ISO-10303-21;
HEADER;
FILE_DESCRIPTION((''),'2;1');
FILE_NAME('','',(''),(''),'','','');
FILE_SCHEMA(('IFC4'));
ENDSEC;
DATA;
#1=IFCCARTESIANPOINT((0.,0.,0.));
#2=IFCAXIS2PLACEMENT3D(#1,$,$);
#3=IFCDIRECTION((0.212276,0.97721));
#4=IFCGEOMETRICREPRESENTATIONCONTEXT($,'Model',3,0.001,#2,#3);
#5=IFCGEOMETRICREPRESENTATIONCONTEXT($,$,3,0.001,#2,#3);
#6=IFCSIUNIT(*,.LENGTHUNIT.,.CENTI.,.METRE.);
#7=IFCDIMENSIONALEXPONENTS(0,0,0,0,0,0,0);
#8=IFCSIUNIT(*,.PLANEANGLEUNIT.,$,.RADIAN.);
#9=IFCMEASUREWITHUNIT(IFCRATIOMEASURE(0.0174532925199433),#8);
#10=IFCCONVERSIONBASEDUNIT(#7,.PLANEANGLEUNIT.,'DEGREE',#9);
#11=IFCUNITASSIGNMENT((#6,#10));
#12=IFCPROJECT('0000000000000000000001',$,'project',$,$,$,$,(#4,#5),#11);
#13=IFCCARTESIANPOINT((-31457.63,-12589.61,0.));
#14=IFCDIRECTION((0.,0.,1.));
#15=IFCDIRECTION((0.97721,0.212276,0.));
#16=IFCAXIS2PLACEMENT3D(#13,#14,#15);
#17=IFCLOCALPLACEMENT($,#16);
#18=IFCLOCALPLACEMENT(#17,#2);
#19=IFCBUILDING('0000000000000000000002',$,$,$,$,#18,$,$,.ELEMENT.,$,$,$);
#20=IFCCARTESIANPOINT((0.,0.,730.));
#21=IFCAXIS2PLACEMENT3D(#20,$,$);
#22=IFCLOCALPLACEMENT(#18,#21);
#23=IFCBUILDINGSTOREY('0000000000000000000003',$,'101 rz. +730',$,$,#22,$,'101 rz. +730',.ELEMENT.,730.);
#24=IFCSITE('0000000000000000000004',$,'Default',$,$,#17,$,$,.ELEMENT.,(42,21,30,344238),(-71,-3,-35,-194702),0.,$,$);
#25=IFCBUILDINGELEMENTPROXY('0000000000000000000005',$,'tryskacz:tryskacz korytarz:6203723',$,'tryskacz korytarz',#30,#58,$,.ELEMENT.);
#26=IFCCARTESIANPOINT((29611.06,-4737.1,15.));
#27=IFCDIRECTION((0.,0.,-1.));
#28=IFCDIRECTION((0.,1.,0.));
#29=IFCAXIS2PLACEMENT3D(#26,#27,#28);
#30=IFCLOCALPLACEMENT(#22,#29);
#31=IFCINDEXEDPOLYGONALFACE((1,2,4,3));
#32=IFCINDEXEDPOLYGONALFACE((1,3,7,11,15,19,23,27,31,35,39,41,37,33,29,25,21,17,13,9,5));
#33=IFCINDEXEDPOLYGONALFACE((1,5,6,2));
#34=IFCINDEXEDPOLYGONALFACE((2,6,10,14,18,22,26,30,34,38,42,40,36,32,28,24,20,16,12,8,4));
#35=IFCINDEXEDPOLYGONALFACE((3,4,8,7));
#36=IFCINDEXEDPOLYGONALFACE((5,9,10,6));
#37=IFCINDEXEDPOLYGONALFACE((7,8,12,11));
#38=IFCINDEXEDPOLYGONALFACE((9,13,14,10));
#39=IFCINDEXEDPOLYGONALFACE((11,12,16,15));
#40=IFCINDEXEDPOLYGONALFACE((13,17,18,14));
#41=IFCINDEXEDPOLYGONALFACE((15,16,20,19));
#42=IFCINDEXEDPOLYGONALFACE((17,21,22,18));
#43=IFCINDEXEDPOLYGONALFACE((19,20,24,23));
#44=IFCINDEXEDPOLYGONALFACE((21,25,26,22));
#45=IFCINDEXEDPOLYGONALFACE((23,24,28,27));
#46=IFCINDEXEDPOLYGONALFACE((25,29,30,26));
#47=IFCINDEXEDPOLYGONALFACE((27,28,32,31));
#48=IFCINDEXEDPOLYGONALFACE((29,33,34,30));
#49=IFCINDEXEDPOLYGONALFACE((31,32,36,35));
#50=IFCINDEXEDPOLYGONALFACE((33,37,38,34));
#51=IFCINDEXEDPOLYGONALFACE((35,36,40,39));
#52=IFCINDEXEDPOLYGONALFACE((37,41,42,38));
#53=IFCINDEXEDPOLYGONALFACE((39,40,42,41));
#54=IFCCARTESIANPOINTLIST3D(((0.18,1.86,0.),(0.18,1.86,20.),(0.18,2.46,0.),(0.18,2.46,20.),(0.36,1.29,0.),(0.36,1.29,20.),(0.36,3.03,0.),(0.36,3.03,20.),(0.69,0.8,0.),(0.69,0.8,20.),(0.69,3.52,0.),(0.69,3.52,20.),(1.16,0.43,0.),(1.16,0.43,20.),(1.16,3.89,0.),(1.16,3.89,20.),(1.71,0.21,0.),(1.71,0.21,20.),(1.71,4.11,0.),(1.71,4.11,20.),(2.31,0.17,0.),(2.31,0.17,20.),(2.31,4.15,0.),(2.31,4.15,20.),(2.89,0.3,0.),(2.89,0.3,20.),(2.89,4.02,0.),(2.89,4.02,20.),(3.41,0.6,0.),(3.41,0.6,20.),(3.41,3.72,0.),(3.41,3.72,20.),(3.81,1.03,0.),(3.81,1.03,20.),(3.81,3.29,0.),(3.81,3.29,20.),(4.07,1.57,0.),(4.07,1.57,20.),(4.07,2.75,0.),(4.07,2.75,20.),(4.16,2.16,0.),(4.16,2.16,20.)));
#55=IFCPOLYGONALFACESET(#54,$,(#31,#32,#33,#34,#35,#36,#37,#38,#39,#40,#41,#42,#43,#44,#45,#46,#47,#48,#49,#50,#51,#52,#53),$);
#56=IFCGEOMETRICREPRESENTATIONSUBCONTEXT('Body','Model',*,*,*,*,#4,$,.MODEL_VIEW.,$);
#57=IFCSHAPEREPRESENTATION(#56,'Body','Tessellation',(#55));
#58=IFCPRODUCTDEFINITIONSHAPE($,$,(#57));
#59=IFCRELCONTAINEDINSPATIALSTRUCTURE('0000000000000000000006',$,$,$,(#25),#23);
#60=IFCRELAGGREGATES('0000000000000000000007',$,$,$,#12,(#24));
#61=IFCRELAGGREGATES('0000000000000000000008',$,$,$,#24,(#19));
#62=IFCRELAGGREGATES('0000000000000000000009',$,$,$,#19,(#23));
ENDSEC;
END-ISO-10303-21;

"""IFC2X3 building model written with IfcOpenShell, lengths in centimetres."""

from ifc_helpers import new_model, entity, si_unit, converted_unit, direction, frame, frame_2d, origin, place, context, subcontext, project, spatial, circle, extrude, source, transform, mapped, element, save


model = new_model("IFC2X3")

# Units and contexts
model_context = context("Model", 3, precision=0.001, world=origin(), true_north=direction((0.212276, 0.97721)))
context_of_model = context(None, 3, precision=0.001, world=origin(), true_north=direction((0.212276, 0.97721)))
body_context = subcontext(model_context, "Body", "Model", "MODEL_VIEW")
ifc_project = project(units=[si_unit("LENGTHUNIT", "METRE", prefix="CENTI"), converted_unit("PLANEANGLEUNIT", "DEGREE", entity("IfcRatioMeasure", 0.0174532925199433), si_unit("PLANEANGLEUNIT", "RADIAN"), dimensions=[0, 0, 0, 0, 0, 0, 0])], contexts=[model_context, context_of_model])

# Site, building, storey
site_placement = place(None, frame((-31457.63, -12589.61, 0.0), z_axis=(0.0, 0.0, 1.0), x_axis=(0.97721, 0.212276, 0.0)))
site = spatial("IfcSite", under=ifc_project, at=site_placement, Name="Default", CompositionType="ELEMENT", RefLatitude=(42, 21, 30, 344238), RefLongitude=(-71, -3, -35, -194702), RefElevation=0.0)
building_placement = place(site_placement, origin())
building = spatial("IfcBuilding", under=site, at=building_placement, CompositionType="ELEMENT")
storey_placement = place(building_placement, frame((0.0, 0.0, 730.0)))
storey = spatial("IfcBuildingStorey", under=building, at=storey_placement, Name="101 rz. +730", LongName="101 rz. +730", CompositionType="ELEMENT", Elevation=730.0)

# Building element proxy
shared_shape_1 = source(origin(), body_context, "Body", "SweptSolid", [
    extrude(circle(Radius=2.0, at=frame_2d((0.0, 0.0), x_axis=(1.0, 0.0))), frame((2.16, 2.16, 0.0)), (0.0, 0.0, 1.0), 20.0),
])
for number, where, z_axis, x_axis, name in (
    (1, (29611.06, -4737.1, 15.0), (0.0, 0.0, -1.0), (0.0, 1.0, 0.0), "tryskacz:tryskacz korytarz:6203723"),
):
    element("IfcBuildingElementProxy", number, at=place(storey_placement, frame(where, z_axis=z_axis, x_axis=x_axis)), inside=storey, Name=name, ObjectType="tryskacz korytarz", CompositionType="ELEMENT", context=body_context, shape_type="MappedRepresentation", body=[
        mapped(shared_shape_1, transform((0.0, 0.0, 0.0), scale=1.0)),
    ])

save(model, "model.ifc")
